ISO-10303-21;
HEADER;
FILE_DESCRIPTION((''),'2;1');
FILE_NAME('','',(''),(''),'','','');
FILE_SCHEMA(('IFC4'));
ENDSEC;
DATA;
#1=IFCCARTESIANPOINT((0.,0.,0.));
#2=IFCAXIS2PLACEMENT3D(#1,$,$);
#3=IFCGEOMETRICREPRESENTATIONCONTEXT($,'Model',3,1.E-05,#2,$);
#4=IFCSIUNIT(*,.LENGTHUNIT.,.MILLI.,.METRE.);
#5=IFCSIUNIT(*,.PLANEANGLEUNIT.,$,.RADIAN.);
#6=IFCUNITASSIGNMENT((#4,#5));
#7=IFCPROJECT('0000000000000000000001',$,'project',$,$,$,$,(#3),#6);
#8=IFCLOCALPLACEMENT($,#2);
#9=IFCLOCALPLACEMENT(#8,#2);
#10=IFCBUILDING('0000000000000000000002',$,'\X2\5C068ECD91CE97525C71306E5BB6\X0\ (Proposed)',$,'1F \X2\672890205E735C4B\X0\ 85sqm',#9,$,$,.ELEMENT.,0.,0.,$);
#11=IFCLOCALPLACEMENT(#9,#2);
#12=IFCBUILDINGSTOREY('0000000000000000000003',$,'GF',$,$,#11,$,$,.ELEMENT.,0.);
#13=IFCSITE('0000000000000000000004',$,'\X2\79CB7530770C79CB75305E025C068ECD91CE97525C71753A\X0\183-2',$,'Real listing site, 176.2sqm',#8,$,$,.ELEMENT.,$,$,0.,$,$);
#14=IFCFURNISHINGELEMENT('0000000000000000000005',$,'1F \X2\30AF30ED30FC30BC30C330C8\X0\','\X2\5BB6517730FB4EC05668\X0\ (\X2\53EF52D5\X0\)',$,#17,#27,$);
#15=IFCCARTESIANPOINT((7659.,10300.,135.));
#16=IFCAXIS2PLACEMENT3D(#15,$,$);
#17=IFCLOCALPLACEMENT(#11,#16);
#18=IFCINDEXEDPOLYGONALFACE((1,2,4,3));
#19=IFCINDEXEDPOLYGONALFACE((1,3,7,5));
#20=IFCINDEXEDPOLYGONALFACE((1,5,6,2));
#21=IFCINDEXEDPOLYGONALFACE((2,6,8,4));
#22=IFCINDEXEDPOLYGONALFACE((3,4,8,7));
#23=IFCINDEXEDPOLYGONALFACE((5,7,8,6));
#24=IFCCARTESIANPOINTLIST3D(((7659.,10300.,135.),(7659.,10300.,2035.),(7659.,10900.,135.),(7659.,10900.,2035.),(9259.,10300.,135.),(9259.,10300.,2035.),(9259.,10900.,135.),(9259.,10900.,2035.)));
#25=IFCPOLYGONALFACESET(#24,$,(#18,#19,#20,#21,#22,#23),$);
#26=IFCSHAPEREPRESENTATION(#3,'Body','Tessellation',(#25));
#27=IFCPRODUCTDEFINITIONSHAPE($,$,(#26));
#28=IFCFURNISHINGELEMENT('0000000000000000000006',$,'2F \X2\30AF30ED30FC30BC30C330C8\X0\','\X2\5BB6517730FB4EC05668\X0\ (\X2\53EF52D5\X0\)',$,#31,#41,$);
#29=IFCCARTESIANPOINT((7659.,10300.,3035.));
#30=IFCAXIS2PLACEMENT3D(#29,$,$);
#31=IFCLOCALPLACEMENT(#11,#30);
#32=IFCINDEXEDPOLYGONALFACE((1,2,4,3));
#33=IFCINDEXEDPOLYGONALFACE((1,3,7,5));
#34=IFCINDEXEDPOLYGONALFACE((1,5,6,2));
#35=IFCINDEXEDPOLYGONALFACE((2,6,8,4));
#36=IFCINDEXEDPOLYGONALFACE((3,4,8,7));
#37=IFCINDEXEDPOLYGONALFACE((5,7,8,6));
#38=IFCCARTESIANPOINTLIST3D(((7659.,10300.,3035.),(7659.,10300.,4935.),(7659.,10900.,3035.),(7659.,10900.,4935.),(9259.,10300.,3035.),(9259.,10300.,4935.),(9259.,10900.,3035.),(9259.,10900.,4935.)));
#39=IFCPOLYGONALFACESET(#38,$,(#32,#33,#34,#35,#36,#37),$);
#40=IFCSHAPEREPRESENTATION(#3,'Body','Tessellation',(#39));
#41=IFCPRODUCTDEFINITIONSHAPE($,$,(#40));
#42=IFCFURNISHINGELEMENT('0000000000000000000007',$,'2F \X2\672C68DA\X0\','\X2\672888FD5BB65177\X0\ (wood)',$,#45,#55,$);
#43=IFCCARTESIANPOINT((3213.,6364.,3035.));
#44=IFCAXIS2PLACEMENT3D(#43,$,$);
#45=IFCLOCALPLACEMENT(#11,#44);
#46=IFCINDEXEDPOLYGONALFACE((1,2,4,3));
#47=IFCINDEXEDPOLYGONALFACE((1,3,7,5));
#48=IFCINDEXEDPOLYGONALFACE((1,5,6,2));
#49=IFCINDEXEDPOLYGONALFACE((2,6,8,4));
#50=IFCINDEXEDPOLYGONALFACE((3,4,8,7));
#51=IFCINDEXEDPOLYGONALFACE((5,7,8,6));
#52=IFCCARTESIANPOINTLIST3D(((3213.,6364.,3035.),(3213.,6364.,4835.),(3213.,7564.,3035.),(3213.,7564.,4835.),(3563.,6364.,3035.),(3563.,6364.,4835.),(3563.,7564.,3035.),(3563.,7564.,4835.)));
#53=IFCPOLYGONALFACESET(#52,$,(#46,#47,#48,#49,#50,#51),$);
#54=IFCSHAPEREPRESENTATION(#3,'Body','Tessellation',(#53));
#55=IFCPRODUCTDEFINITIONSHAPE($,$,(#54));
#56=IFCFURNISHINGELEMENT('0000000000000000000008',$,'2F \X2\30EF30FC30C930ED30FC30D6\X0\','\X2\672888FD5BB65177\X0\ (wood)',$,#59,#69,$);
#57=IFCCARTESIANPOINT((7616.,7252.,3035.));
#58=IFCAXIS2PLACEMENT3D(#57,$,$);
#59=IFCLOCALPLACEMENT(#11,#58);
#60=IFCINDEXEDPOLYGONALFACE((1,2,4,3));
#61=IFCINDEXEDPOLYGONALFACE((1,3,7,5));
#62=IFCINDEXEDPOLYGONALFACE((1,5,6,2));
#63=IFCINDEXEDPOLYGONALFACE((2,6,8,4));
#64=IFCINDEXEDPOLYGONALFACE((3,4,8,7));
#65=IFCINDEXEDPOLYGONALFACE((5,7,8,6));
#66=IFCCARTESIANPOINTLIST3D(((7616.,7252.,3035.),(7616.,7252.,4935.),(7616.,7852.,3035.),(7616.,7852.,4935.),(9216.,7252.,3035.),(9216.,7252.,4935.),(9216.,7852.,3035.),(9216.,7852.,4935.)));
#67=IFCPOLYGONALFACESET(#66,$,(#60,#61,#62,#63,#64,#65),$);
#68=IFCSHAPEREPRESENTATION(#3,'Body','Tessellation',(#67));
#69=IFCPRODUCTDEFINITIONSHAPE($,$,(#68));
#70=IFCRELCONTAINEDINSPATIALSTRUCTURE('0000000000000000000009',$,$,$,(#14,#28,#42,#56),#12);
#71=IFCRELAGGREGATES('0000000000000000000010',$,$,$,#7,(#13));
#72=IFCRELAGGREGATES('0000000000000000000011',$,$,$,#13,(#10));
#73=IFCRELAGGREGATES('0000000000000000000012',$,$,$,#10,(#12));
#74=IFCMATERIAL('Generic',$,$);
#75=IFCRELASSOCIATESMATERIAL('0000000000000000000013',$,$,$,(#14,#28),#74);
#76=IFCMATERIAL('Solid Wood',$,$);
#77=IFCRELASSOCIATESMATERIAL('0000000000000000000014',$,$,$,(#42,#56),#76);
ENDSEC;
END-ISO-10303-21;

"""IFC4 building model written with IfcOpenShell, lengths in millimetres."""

from ifc_helpers import new_model, si_unit, frame, frame_2d, origin, place, context, project, spatial, rectangle, extrude, material, element, save


model = new_model("IFC4")

# Units and contexts
model_context = context("Model", 3, precision=1e-05, world=origin())
ifc_project = project(units=[si_unit("LENGTHUNIT", "METRE", prefix="MILLI"), si_unit("PLANEANGLEUNIT", "RADIAN")], contexts=[model_context])

# Site, building, storey
site_placement = place(None, origin())
site = spatial("IfcSite", under=ifc_project, at=site_placement, Name="秋田県秋田市将軍野青山町183-2", ObjectType="Real listing site, 176.2sqm", CompositionType="ELEMENT", RefElevation=0.0)
building_placement = place(site_placement, origin())
building = spatial("IfcBuilding", under=site, at=building_placement, Name="将軍野青山の家 (Proposed)", ObjectType="1F 木造平屋 85sqm", CompositionType="ELEMENT", ElevationOfRefHeight=0.0, ElevationOfTerrain=0.0)
storey_placement = place(building_placement, origin())
storey = spatial("IfcBuildingStorey", under=building, at=storey_placement, Name="GF", CompositionType="ELEMENT", Elevation=0.0)

# Shared definitions
ifc_material_1 = material(Name="Solid Wood")

# Shared definitions
ifc_material_2 = material(Name="Generic")

# Furnishing elements
furnishing_1_placement = place(storey_placement, frame((7659.0, 10300.0, 135.0)))
element("IfcFurnishingElement", 1, at=furnishing_1_placement, inside=storey, material=ifc_material_2, Name="1F クローゼット", Description="家具・什器 (可動)", context=model_context, shape_type="SweptSolid", body=[
    extrude(rectangle(XDim=1600.0, YDim=600.0, at=frame_2d((800.0, 300.0))), frame((7659.0, 10300.0, 135.0)), (0.0, 0.0, 1.0), 1900.0),
])
furnishing_2_placement = place(storey_placement, frame((7659.0, 10300.0, 3035.0)))
element("IfcFurnishingElement", 2, at=furnishing_2_placement, inside=storey, material=ifc_material_2, Name="2F クローゼット", Description="家具・什器 (可動)", context=model_context, shape_type="SweptSolid", body=[
    extrude(rectangle(XDim=1600.0, YDim=600.0, at=frame_2d((800.0, 300.0))), frame((7659.0, 10300.0, 3035.0)), (0.0, 0.0, 1.0), 1900.0),
])
furnishing_3_placement = place(storey_placement, frame((3213.0, 6364.0, 3035.0)))
element("IfcFurnishingElement", 3, at=furnishing_3_placement, inside=storey, material=ifc_material_1, Name="2F 本棚", Description="木製家具 (wood)", context=model_context, shape_type="SweptSolid", body=[
    extrude(rectangle(XDim=350.0, YDim=1200.0, at=frame_2d((175.0, 600.0))), frame((3213.0, 6364.0, 3035.0)), (0.0, 0.0, 1.0), 1800.0),
])
furnishing_4_placement = place(storey_placement, frame((7616.0, 7252.0, 3035.0)))
element("IfcFurnishingElement", 4, at=furnishing_4_placement, inside=storey, material=ifc_material_1, Name="2F ワードローブ", Description="木製家具 (wood)", context=model_context, shape_type="SweptSolid", body=[
    extrude(rectangle(XDim=1600.0, YDim=600.0, at=frame_2d((800.0, 300.0))), frame((7616.0, 7252.0, 3035.0)), (0.0, 0.0, 1.0), 1900.0),
])

save(model, "model.ifc")
